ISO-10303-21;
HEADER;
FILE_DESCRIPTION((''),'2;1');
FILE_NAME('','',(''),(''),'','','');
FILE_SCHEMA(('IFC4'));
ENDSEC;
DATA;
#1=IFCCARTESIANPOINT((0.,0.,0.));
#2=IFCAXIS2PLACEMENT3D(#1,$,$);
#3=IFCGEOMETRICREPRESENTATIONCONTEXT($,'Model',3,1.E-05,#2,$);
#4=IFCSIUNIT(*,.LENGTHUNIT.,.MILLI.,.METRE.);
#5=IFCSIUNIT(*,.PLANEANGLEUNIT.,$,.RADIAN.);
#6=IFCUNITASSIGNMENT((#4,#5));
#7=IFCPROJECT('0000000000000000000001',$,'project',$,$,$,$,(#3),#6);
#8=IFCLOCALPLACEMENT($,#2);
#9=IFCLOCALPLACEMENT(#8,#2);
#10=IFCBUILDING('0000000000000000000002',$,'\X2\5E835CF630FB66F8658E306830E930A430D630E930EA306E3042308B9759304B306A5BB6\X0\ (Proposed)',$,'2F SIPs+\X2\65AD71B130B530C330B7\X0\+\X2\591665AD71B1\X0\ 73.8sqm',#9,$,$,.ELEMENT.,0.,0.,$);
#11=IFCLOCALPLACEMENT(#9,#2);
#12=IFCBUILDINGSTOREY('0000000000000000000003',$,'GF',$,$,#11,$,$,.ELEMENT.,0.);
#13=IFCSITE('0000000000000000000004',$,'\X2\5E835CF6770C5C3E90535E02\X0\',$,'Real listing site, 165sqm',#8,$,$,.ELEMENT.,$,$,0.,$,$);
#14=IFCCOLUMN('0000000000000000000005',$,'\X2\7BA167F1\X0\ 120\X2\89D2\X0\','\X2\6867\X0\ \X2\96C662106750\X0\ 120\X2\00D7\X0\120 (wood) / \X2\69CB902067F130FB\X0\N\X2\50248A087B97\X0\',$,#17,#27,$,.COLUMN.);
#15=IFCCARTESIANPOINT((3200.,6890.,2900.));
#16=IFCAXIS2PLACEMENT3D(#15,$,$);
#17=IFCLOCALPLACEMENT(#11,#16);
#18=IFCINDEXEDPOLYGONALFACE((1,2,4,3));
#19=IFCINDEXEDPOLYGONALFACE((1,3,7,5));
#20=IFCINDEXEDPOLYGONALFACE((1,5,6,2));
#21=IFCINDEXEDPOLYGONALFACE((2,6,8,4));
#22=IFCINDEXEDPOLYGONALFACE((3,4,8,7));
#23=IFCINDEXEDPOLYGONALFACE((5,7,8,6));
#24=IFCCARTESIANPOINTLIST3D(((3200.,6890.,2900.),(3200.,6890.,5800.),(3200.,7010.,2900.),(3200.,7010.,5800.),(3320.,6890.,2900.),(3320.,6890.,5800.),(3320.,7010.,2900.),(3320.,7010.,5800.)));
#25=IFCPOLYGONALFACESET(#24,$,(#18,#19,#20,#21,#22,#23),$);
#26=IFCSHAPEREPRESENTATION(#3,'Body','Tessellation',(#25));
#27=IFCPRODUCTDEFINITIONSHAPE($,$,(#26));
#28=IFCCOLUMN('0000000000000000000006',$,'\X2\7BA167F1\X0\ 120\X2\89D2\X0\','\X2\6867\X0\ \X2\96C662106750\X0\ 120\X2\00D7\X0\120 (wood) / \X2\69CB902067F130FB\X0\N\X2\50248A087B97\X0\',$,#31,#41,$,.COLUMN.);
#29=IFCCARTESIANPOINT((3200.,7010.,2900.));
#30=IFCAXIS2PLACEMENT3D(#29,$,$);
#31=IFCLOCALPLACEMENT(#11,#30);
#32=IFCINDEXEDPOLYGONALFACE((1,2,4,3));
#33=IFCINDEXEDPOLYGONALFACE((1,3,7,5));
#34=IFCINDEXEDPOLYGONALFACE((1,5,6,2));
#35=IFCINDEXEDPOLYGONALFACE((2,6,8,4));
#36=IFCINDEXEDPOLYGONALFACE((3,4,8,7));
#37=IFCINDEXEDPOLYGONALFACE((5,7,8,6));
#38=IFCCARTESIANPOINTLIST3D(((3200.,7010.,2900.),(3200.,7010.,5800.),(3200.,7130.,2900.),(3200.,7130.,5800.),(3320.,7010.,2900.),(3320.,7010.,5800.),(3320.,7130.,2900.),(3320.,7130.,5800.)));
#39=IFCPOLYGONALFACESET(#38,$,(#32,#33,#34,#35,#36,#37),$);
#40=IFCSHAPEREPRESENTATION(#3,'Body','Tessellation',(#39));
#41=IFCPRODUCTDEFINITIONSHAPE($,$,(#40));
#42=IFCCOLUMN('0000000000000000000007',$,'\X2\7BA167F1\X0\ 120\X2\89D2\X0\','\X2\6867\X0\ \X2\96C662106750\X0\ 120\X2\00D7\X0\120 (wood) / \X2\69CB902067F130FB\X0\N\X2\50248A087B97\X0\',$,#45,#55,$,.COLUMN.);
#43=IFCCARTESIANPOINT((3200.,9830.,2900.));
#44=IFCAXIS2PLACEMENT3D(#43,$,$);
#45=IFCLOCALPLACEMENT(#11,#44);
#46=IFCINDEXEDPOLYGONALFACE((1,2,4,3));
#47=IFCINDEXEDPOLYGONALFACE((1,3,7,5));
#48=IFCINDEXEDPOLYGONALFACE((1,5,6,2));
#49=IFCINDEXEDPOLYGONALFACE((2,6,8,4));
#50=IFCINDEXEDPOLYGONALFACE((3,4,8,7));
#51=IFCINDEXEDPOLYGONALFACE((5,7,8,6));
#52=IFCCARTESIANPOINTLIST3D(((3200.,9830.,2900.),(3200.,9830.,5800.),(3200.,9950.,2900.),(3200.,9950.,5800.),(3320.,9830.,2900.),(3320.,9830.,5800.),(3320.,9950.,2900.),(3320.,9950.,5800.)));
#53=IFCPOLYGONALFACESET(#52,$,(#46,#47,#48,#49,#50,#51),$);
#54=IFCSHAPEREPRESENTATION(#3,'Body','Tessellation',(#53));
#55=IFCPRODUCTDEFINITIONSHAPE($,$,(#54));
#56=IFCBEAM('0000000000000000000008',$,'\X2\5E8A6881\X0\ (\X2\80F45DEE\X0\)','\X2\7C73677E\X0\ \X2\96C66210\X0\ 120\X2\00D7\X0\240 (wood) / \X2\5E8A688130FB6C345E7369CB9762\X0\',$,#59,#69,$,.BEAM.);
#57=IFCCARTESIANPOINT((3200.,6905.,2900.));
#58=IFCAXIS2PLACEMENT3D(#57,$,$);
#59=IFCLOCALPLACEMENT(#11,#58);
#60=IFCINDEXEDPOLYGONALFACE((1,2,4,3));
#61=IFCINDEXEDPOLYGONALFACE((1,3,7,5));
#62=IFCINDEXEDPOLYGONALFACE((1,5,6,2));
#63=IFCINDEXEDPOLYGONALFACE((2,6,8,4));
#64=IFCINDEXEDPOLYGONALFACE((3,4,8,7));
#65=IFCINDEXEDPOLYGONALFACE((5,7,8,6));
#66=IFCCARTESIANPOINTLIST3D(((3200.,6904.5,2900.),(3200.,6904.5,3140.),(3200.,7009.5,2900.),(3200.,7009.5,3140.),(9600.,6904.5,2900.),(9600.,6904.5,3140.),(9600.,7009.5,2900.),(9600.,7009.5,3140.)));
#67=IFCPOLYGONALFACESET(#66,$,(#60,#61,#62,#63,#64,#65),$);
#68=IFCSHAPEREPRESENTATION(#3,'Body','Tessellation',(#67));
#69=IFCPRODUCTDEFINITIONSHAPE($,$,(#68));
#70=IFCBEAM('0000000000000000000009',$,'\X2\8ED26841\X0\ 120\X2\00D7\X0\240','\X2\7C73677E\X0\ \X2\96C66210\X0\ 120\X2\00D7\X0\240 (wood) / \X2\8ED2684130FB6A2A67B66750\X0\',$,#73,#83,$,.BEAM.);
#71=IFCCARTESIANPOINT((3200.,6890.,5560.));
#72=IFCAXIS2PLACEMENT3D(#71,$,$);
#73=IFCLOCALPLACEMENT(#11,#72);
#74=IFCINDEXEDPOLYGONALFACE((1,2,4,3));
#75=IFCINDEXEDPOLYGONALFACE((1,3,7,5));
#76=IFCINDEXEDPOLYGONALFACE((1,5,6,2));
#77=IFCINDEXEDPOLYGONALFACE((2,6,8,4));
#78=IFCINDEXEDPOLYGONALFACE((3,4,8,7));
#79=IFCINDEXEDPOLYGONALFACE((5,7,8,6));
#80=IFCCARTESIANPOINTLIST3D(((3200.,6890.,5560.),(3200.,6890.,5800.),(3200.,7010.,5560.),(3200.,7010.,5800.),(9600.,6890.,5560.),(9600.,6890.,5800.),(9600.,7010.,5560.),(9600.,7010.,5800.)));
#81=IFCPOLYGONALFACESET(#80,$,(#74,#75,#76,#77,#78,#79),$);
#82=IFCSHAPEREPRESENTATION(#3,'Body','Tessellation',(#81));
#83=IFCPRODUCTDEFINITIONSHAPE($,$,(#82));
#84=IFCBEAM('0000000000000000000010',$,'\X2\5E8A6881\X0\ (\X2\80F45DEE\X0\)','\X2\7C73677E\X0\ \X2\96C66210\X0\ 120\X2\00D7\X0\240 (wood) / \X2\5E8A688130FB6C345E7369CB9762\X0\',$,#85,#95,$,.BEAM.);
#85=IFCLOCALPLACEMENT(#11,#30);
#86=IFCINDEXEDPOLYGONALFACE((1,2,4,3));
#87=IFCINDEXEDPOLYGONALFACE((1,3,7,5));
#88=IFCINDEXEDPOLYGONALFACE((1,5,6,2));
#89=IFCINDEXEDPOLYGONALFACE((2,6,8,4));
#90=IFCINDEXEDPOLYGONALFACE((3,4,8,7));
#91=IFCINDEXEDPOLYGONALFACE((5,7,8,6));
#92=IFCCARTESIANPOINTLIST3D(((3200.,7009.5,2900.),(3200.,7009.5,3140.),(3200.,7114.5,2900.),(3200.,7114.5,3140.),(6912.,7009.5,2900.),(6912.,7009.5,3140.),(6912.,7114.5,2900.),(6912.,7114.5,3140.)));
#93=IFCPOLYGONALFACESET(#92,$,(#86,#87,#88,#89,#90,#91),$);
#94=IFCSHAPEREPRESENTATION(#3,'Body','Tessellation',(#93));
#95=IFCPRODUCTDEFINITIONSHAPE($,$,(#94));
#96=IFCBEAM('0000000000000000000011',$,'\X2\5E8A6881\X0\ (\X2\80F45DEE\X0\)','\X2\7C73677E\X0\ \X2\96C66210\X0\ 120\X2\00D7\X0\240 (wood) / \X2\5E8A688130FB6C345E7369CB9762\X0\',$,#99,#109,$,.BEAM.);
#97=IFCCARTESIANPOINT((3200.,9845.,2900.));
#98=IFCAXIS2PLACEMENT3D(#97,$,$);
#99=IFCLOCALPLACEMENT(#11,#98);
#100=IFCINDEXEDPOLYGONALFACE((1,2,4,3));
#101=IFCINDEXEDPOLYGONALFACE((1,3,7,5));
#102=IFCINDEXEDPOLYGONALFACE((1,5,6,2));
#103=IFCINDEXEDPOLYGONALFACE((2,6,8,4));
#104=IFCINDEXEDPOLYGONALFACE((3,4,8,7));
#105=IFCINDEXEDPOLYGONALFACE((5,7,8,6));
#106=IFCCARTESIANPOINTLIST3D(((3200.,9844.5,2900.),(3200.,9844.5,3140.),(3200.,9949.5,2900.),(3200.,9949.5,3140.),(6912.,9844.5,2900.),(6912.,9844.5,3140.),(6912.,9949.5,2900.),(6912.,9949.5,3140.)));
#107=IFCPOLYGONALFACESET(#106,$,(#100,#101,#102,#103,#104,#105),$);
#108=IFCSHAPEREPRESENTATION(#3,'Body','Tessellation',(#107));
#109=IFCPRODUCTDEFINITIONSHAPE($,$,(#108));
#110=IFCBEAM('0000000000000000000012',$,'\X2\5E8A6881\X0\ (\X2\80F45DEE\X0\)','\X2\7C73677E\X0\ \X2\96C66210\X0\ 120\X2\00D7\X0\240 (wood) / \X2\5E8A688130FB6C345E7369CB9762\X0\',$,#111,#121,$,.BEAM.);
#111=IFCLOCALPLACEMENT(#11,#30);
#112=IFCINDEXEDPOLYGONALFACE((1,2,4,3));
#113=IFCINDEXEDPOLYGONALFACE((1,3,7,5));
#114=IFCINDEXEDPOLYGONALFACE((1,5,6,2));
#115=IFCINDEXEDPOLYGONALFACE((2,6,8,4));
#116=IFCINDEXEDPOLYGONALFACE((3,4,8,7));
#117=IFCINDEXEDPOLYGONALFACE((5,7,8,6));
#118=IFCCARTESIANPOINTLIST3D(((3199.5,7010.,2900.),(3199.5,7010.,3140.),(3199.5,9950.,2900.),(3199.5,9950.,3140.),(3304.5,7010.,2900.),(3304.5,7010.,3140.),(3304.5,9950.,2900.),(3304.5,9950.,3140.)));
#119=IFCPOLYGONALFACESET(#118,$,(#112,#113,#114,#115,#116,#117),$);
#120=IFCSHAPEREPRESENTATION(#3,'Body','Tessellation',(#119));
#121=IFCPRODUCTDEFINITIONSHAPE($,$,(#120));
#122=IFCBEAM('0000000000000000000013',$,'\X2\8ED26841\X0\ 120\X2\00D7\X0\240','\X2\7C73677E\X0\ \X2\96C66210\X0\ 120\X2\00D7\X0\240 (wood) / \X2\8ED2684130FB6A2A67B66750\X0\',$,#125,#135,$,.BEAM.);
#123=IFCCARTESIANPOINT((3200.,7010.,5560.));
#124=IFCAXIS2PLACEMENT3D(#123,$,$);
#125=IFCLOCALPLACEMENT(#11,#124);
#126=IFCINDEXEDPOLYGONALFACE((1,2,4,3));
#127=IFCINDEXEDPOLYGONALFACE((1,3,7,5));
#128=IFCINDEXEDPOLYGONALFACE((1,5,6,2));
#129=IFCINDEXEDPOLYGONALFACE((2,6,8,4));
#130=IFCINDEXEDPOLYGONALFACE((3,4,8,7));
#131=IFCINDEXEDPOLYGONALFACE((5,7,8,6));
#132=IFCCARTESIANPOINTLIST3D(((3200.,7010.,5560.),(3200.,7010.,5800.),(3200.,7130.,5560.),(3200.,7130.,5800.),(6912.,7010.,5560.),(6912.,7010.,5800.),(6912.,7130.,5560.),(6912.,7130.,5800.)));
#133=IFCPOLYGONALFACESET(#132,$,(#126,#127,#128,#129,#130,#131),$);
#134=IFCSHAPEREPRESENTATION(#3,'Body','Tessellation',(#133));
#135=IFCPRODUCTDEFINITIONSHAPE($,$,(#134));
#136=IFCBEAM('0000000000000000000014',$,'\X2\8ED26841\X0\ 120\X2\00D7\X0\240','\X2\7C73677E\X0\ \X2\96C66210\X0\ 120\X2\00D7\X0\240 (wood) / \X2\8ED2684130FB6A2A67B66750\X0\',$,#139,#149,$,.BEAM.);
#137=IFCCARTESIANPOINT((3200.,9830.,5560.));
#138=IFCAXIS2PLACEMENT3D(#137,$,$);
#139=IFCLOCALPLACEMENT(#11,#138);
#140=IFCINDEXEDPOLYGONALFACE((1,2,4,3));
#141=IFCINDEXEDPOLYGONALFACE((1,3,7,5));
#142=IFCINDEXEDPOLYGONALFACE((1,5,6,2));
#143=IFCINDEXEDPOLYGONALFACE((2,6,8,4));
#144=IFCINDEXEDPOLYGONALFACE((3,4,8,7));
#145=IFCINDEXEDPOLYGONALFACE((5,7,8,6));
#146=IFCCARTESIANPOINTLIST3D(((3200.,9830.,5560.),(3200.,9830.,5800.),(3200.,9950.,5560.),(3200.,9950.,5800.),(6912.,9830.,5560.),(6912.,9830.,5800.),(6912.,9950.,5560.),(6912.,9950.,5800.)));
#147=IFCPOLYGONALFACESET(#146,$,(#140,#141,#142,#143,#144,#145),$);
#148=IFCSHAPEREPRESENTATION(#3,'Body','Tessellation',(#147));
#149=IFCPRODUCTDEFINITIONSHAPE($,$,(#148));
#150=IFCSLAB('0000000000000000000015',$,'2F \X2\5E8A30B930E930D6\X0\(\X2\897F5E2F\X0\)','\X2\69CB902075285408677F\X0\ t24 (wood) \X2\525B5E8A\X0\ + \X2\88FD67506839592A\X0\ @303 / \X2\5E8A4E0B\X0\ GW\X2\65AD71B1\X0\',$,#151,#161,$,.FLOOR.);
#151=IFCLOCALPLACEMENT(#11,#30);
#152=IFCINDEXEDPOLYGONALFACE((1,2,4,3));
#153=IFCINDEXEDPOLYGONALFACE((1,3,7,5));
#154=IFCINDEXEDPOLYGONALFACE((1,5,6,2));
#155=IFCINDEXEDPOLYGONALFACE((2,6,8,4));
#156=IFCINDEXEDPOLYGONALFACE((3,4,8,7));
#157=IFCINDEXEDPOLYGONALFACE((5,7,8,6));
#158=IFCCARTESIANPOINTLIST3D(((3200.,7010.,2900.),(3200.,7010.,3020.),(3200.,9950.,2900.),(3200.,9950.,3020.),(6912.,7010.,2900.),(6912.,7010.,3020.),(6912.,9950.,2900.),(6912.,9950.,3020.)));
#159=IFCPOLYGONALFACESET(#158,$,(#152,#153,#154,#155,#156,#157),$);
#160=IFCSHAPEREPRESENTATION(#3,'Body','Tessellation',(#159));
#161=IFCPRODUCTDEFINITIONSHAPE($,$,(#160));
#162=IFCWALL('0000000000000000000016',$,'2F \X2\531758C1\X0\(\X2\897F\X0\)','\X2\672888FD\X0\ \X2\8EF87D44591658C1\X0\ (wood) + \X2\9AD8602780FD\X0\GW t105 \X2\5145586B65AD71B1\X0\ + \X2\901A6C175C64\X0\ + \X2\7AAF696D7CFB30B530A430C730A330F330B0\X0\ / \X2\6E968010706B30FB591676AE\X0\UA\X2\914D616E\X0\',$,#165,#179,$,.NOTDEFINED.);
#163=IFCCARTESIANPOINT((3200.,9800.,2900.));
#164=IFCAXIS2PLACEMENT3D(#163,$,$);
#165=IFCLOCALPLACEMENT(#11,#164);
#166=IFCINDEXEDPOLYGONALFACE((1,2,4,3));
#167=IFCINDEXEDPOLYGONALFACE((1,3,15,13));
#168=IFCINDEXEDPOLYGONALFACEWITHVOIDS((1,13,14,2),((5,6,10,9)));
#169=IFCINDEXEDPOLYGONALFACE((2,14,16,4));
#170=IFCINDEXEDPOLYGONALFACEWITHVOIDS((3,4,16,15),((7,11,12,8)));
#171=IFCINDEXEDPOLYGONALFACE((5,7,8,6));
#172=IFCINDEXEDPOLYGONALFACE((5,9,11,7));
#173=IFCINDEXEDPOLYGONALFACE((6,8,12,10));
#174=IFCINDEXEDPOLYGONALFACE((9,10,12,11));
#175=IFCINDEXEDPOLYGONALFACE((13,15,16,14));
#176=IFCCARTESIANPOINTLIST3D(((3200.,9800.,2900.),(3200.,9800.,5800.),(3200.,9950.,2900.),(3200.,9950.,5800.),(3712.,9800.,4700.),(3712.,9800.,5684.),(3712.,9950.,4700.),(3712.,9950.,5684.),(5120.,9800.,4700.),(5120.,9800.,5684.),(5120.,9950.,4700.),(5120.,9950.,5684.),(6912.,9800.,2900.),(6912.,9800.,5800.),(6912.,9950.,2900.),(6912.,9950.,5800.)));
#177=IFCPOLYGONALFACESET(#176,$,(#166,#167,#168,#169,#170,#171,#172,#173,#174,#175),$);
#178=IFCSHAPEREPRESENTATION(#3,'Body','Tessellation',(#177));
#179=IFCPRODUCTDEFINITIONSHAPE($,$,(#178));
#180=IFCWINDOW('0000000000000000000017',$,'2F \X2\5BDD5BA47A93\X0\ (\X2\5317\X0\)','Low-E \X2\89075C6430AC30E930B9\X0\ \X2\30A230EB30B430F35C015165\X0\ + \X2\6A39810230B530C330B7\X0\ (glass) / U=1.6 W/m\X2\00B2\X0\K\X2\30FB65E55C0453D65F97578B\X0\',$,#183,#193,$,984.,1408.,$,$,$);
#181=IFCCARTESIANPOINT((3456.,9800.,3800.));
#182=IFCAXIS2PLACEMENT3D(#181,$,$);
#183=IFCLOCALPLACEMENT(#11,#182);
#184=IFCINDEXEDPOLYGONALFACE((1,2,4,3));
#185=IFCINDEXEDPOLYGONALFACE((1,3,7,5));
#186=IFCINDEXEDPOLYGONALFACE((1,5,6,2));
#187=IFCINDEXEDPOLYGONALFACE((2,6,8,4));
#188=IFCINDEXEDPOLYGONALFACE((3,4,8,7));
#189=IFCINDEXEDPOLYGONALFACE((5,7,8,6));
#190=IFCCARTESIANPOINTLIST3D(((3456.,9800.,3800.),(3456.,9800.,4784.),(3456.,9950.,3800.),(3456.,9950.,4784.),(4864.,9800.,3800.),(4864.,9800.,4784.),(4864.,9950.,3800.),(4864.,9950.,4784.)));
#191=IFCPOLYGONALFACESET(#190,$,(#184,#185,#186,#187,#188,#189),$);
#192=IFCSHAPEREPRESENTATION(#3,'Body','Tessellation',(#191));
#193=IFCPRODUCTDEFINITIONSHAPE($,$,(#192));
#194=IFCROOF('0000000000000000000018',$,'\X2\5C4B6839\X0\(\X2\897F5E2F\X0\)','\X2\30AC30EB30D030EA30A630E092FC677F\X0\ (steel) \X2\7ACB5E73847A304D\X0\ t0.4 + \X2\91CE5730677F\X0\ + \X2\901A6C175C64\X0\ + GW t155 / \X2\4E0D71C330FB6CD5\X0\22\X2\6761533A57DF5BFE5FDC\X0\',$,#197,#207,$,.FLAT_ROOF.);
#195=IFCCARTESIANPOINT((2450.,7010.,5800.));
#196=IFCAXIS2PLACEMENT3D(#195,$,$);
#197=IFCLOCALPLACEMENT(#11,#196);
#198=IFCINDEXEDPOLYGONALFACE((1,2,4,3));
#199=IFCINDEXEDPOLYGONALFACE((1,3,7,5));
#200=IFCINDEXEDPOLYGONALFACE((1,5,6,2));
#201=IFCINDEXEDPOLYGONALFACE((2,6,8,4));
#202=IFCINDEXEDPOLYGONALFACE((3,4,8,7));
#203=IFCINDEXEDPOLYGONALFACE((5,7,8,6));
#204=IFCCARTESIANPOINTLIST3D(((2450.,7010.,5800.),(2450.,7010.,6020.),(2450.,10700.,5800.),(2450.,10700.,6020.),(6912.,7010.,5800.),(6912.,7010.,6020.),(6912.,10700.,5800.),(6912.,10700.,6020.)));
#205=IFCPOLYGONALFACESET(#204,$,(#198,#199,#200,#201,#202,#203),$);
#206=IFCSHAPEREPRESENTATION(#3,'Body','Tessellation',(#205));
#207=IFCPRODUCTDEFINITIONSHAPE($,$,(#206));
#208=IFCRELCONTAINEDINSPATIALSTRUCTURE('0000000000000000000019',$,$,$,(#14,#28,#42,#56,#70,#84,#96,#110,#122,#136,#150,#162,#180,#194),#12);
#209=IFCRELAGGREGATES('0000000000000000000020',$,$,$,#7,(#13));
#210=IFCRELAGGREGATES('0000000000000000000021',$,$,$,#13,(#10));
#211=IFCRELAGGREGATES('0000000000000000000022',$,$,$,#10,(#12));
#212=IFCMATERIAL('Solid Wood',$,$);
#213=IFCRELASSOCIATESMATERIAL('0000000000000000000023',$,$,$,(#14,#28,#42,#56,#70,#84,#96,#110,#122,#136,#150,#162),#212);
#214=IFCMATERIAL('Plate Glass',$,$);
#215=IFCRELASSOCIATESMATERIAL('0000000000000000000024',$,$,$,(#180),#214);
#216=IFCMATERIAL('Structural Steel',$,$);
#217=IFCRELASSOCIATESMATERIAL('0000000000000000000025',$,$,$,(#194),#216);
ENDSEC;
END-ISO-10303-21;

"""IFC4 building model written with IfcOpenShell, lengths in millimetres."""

from ifc_helpers import new_model, si_unit, frame, frame_2d, origin, place, context, project, spatial, rectangle, extrude, material, element, fill, save


model = new_model("IFC4")

# Units and contexts
model_context = context("Model", 3, precision=1e-05, world=origin())
ifc_project = project(units=[si_unit("LENGTHUNIT", "METRE", prefix="MILLI"), si_unit("PLANEANGLEUNIT", "RADIAN")], contexts=[model_context])

# Site, building, storey
site_placement = place(None, origin())
site = spatial("IfcSite", under=ifc_project, at=site_placement, Name="広島県尾道市", ObjectType="Real listing site, 165sqm", CompositionType="ELEMENT", RefElevation=0.0)
building_placement = place(site_placement, origin())
building = spatial("IfcBuilding", under=site, at=building_placement, Name="広島・書斎とライブラリのある静かな家 (Proposed)", ObjectType="2F SIPs+断熱サッシ+外断熱 73.8sqm", CompositionType="ELEMENT", ElevationOfRefHeight=0.0, ElevationOfTerrain=0.0)
storey_placement = place(building_placement, origin())
storey = spatial("IfcBuildingStorey", under=building, at=storey_placement, Name="GF", CompositionType="ELEMENT", Elevation=0.0)

# Columns
ifc_material_1 = material(Name="Solid Wood")
column_1_placement = place(storey_placement, frame((3200.0, 6890.0, 2900.0)))
element("IfcColumn", 1, at=column_1_placement, inside=storey, material=ifc_material_1, Name="管柱 120角", Description="桧 集成材 120×120 (wood) / 構造柱・N値計算", PredefinedType="COLUMN", context=model_context, shape_type="SweptSolid", body=[
    extrude(rectangle(XDim=120.0, YDim=120.0, at=frame_2d((60.0, 60.0))), frame((3200.0, 6890.0, 2900.0)), (0.0, 0.0, 1.0), 2900.0),
])
column_2_placement = place(storey_placement, frame((3200.0, 7010.0, 2900.0)))
element("IfcColumn", 2, at=column_2_placement, inside=storey, material=ifc_material_1, Name="管柱 120角", Description="桧 集成材 120×120 (wood) / 構造柱・N値計算", PredefinedType="COLUMN", context=model_context, shape_type="SweptSolid", body=[
    extrude(rectangle(XDim=120.0, YDim=120.0, at=frame_2d((60.0, 60.0))), frame((3200.0, 7010.0, 2900.0)), (0.0, 0.0, 1.0), 2900.0),
])
column_3_placement = place(storey_placement, frame((3200.0, 9830.0, 2900.0)))
element("IfcColumn", 3, at=column_3_placement, inside=storey, material=ifc_material_1, Name="管柱 120角", Description="桧 集成材 120×120 (wood) / 構造柱・N値計算", PredefinedType="COLUMN", context=model_context, shape_type="SweptSolid", body=[
    extrude(rectangle(XDim=120.0, YDim=120.0, at=frame_2d((60.0, 60.0))), frame((3200.0, 9830.0, 2900.0)), (0.0, 0.0, 1.0), 2900.0),
])

# Beams
beam_1_placement = place(storey_placement, frame((3200.0, 6905.0, 2900.0)))
element("IfcBeam", 4, at=beam_1_placement, inside=storey, material=ifc_material_1, Name="床梁 (胴差)", Description="米松 集成 120×240 (wood) / 床梁・水平構面", PredefinedType="BEAM", context=model_context, shape_type="SweptSolid", body=[
    extrude(rectangle(XDim=6400.0, YDim=105.0, at=frame_2d((3200.0, 52.0))), frame((3200.0, 6905.0, 2900.0)), (0.0, 0.0, 1.0), 240.0),
])
beam_2_placement = place(storey_placement, frame((3200.0, 6890.0, 5560.0)))
element("IfcBeam", 5, at=beam_2_placement, inside=storey, material=ifc_material_1, Name="軒桁 120×240", Description="米松 集成 120×240 (wood) / 軒桁・横架材", PredefinedType="BEAM", context=model_context, shape_type="SweptSolid", body=[
    extrude(rectangle(XDim=6400.0, YDim=120.0, at=frame_2d((3200.0, 60.0))), frame((3200.0, 6890.0, 5560.0)), (0.0, 0.0, 1.0), 240.0),
])
beam_3_placement = place(storey_placement, frame((3200.0, 7010.0, 2900.0)))
element("IfcBeam", 6, at=beam_3_placement, inside=storey, material=ifc_material_1, Name="床梁 (胴差)", Description="米松 集成 120×240 (wood) / 床梁・水平構面", PredefinedType="BEAM", context=model_context, shape_type="SweptSolid", body=[
    extrude(rectangle(XDim=3712.0, YDim=105.0, at=frame_2d((1856.0, 52.0))), frame((3200.0, 7010.0, 2900.0)), (0.0, 0.0, 1.0), 240.0),
])
beam_4_placement = place(storey_placement, frame((3200.0, 9845.0, 2900.0)))
element("IfcBeam", 7, at=beam_4_placement, inside=storey, material=ifc_material_1, Name="床梁 (胴差)", Description="米松 集成 120×240 (wood) / 床梁・水平構面", PredefinedType="BEAM", context=model_context, shape_type="SweptSolid", body=[
    extrude(rectangle(XDim=3712.0, YDim=105.0, at=frame_2d((1856.0, 52.0))), frame((3200.0, 9845.0, 2900.0)), (0.0, 0.0, 1.0), 240.0),
])
beam_5_placement = place(storey_placement, frame((3200.0, 7010.0, 2900.0)))
element("IfcBeam", 8, at=beam_5_placement, inside=storey, material=ifc_material_1, Name="床梁 (胴差)", Description="米松 集成 120×240 (wood) / 床梁・水平構面", PredefinedType="BEAM", context=model_context, shape_type="SweptSolid", body=[
    extrude(rectangle(XDim=105.0, YDim=2940.0, at=frame_2d((52.0, 1470.0))), frame((3200.0, 7010.0, 2900.0)), (0.0, 0.0, 1.0), 240.0),
])
beam_6_placement = place(storey_placement, frame((3200.0, 7010.0, 5560.0)))
element("IfcBeam", 9, at=beam_6_placement, inside=storey, material=ifc_material_1, Name="軒桁 120×240", Description="米松 集成 120×240 (wood) / 軒桁・横架材", PredefinedType="BEAM", context=model_context, shape_type="SweptSolid", body=[
    extrude(rectangle(XDim=3712.0, YDim=120.0, at=frame_2d((1856.0, 60.0))), frame((3200.0, 7010.0, 5560.0)), (0.0, 0.0, 1.0), 240.0),
])
beam_7_placement = place(storey_placement, frame((3200.0, 9830.0, 5560.0)))
element("IfcBeam", 10, at=beam_7_placement, inside=storey, material=ifc_material_1, Name="軒桁 120×240", Description="米松 集成 120×240 (wood) / 軒桁・横架材", PredefinedType="BEAM", context=model_context, shape_type="SweptSolid", body=[
    extrude(rectangle(XDim=3712.0, YDim=120.0, at=frame_2d((1856.0, 60.0))), frame((3200.0, 9830.0, 5560.0)), (0.0, 0.0, 1.0), 240.0),
])

# Slab
slab_placement = place(storey_placement, frame((3200.0, 7010.0, 2900.0)))
element("IfcSlab", 11, at=slab_placement, inside=storey, material=ifc_material_1, Name="2F 床スラブ(西帯)", Description="構造用合板 t24 (wood) 剛床 + 製材根太 @303 / 床下 GW断熱", PredefinedType="FLOOR", context=model_context, shape_type="SweptSolid", body=[
    extrude(rectangle(XDim=3712.0, YDim=2940.0, at=frame_2d((1856.0, 1470.0))), frame((3200.0, 7010.0, 2900.0)), (0.0, 0.0, 1.0), 120.0),
])

# Wall, opening, window
wall_1_placement = place(storey_placement, frame((3200.0, 9800.0, 2900.0)))
wall_1 = element("IfcWall", 12, at=wall_1_placement, inside=storey, material=ifc_material_1, Name="2F 北壁(西)", Description="木製 軸組外壁 (wood) + 高性能GW t105 充填断熱 + 通気層 + 窯業系サイディング / 準耐火・外皮UA配慮", PredefinedType="NOTDEFINED", context=model_context, shape_type="SweptSolid", body=[
    extrude(rectangle(XDim=3712.0, YDim=150.0, at=frame_2d((1856.0, 75.0))), frame((3200.0, 9800.0, 2900.0)), (0.0, 0.0, 1.0), 2900.0),
])
opening_placement = place(storey_placement, frame((3456.0, 9800.0, 3800.0)))
opening = element("IfcOpeningElement", 13, at=opening_placement, cuts=wall_1, PredefinedType="NOTDEFINED", context=model_context, shape_type="SweptSolid", body=[
    extrude(rectangle(XDim=1408.0, YDim=150.0, at=frame_2d((704.0, 75.0))), frame((3456.0, 9800.0, 3800.0)), (0.0, 0.0, 1.0), 984.0),
])
ifc_material_2 = material(Name="Plate Glass")
window_placement = place(storey_placement, frame((3456.0, 9800.0, 3800.0)))
window = element("IfcWindow", 14, at=window_placement, inside=storey, material=ifc_material_2, Name="2F 寝室窓 (北)", Description="Low-E 複層ガラス アルゴン封入 + 樹脂サッシ (glass) / U=1.6 W/m²K・日射取得型", OverallHeight=984.0, OverallWidth=1408.0, context=model_context, shape_type="SweptSolid", body=[
    extrude(rectangle(XDim=1408.0, YDim=150.0, at=frame_2d((704.0, 75.0))), frame((3456.0, 9800.0, 3800.0)), (0.0, 0.0, 1.0), 984.0),
])
fill(opening, window)

# Roof
ifc_material_3 = material(Name="Structural Steel")
for number, where, name in (
    (15, (2450.0, 7010.0, 5800.0), "屋根(西帯)"),
):
    element("IfcRoof", number, at=place(storey_placement, frame(where)), inside=storey, material=ifc_material_3, Name=name, Description="ガルバリウム鋼板 (steel) 立平葺き t0.4 + 野地板 + 通気層 + GW t155 / 不燃・法22条区域対応", PredefinedType="FLAT_ROOF", context=model_context, shape_type="SweptSolid", body=[
        extrude(rectangle(XDim=4462.0, YDim=3690.0, at=frame_2d((2231.0, 1845.0))), frame((2450.0, 7010.0, 5800.0)), (0.0, 0.0, 1.0), 220.0),
    ])

save(model, "model.ifc")
